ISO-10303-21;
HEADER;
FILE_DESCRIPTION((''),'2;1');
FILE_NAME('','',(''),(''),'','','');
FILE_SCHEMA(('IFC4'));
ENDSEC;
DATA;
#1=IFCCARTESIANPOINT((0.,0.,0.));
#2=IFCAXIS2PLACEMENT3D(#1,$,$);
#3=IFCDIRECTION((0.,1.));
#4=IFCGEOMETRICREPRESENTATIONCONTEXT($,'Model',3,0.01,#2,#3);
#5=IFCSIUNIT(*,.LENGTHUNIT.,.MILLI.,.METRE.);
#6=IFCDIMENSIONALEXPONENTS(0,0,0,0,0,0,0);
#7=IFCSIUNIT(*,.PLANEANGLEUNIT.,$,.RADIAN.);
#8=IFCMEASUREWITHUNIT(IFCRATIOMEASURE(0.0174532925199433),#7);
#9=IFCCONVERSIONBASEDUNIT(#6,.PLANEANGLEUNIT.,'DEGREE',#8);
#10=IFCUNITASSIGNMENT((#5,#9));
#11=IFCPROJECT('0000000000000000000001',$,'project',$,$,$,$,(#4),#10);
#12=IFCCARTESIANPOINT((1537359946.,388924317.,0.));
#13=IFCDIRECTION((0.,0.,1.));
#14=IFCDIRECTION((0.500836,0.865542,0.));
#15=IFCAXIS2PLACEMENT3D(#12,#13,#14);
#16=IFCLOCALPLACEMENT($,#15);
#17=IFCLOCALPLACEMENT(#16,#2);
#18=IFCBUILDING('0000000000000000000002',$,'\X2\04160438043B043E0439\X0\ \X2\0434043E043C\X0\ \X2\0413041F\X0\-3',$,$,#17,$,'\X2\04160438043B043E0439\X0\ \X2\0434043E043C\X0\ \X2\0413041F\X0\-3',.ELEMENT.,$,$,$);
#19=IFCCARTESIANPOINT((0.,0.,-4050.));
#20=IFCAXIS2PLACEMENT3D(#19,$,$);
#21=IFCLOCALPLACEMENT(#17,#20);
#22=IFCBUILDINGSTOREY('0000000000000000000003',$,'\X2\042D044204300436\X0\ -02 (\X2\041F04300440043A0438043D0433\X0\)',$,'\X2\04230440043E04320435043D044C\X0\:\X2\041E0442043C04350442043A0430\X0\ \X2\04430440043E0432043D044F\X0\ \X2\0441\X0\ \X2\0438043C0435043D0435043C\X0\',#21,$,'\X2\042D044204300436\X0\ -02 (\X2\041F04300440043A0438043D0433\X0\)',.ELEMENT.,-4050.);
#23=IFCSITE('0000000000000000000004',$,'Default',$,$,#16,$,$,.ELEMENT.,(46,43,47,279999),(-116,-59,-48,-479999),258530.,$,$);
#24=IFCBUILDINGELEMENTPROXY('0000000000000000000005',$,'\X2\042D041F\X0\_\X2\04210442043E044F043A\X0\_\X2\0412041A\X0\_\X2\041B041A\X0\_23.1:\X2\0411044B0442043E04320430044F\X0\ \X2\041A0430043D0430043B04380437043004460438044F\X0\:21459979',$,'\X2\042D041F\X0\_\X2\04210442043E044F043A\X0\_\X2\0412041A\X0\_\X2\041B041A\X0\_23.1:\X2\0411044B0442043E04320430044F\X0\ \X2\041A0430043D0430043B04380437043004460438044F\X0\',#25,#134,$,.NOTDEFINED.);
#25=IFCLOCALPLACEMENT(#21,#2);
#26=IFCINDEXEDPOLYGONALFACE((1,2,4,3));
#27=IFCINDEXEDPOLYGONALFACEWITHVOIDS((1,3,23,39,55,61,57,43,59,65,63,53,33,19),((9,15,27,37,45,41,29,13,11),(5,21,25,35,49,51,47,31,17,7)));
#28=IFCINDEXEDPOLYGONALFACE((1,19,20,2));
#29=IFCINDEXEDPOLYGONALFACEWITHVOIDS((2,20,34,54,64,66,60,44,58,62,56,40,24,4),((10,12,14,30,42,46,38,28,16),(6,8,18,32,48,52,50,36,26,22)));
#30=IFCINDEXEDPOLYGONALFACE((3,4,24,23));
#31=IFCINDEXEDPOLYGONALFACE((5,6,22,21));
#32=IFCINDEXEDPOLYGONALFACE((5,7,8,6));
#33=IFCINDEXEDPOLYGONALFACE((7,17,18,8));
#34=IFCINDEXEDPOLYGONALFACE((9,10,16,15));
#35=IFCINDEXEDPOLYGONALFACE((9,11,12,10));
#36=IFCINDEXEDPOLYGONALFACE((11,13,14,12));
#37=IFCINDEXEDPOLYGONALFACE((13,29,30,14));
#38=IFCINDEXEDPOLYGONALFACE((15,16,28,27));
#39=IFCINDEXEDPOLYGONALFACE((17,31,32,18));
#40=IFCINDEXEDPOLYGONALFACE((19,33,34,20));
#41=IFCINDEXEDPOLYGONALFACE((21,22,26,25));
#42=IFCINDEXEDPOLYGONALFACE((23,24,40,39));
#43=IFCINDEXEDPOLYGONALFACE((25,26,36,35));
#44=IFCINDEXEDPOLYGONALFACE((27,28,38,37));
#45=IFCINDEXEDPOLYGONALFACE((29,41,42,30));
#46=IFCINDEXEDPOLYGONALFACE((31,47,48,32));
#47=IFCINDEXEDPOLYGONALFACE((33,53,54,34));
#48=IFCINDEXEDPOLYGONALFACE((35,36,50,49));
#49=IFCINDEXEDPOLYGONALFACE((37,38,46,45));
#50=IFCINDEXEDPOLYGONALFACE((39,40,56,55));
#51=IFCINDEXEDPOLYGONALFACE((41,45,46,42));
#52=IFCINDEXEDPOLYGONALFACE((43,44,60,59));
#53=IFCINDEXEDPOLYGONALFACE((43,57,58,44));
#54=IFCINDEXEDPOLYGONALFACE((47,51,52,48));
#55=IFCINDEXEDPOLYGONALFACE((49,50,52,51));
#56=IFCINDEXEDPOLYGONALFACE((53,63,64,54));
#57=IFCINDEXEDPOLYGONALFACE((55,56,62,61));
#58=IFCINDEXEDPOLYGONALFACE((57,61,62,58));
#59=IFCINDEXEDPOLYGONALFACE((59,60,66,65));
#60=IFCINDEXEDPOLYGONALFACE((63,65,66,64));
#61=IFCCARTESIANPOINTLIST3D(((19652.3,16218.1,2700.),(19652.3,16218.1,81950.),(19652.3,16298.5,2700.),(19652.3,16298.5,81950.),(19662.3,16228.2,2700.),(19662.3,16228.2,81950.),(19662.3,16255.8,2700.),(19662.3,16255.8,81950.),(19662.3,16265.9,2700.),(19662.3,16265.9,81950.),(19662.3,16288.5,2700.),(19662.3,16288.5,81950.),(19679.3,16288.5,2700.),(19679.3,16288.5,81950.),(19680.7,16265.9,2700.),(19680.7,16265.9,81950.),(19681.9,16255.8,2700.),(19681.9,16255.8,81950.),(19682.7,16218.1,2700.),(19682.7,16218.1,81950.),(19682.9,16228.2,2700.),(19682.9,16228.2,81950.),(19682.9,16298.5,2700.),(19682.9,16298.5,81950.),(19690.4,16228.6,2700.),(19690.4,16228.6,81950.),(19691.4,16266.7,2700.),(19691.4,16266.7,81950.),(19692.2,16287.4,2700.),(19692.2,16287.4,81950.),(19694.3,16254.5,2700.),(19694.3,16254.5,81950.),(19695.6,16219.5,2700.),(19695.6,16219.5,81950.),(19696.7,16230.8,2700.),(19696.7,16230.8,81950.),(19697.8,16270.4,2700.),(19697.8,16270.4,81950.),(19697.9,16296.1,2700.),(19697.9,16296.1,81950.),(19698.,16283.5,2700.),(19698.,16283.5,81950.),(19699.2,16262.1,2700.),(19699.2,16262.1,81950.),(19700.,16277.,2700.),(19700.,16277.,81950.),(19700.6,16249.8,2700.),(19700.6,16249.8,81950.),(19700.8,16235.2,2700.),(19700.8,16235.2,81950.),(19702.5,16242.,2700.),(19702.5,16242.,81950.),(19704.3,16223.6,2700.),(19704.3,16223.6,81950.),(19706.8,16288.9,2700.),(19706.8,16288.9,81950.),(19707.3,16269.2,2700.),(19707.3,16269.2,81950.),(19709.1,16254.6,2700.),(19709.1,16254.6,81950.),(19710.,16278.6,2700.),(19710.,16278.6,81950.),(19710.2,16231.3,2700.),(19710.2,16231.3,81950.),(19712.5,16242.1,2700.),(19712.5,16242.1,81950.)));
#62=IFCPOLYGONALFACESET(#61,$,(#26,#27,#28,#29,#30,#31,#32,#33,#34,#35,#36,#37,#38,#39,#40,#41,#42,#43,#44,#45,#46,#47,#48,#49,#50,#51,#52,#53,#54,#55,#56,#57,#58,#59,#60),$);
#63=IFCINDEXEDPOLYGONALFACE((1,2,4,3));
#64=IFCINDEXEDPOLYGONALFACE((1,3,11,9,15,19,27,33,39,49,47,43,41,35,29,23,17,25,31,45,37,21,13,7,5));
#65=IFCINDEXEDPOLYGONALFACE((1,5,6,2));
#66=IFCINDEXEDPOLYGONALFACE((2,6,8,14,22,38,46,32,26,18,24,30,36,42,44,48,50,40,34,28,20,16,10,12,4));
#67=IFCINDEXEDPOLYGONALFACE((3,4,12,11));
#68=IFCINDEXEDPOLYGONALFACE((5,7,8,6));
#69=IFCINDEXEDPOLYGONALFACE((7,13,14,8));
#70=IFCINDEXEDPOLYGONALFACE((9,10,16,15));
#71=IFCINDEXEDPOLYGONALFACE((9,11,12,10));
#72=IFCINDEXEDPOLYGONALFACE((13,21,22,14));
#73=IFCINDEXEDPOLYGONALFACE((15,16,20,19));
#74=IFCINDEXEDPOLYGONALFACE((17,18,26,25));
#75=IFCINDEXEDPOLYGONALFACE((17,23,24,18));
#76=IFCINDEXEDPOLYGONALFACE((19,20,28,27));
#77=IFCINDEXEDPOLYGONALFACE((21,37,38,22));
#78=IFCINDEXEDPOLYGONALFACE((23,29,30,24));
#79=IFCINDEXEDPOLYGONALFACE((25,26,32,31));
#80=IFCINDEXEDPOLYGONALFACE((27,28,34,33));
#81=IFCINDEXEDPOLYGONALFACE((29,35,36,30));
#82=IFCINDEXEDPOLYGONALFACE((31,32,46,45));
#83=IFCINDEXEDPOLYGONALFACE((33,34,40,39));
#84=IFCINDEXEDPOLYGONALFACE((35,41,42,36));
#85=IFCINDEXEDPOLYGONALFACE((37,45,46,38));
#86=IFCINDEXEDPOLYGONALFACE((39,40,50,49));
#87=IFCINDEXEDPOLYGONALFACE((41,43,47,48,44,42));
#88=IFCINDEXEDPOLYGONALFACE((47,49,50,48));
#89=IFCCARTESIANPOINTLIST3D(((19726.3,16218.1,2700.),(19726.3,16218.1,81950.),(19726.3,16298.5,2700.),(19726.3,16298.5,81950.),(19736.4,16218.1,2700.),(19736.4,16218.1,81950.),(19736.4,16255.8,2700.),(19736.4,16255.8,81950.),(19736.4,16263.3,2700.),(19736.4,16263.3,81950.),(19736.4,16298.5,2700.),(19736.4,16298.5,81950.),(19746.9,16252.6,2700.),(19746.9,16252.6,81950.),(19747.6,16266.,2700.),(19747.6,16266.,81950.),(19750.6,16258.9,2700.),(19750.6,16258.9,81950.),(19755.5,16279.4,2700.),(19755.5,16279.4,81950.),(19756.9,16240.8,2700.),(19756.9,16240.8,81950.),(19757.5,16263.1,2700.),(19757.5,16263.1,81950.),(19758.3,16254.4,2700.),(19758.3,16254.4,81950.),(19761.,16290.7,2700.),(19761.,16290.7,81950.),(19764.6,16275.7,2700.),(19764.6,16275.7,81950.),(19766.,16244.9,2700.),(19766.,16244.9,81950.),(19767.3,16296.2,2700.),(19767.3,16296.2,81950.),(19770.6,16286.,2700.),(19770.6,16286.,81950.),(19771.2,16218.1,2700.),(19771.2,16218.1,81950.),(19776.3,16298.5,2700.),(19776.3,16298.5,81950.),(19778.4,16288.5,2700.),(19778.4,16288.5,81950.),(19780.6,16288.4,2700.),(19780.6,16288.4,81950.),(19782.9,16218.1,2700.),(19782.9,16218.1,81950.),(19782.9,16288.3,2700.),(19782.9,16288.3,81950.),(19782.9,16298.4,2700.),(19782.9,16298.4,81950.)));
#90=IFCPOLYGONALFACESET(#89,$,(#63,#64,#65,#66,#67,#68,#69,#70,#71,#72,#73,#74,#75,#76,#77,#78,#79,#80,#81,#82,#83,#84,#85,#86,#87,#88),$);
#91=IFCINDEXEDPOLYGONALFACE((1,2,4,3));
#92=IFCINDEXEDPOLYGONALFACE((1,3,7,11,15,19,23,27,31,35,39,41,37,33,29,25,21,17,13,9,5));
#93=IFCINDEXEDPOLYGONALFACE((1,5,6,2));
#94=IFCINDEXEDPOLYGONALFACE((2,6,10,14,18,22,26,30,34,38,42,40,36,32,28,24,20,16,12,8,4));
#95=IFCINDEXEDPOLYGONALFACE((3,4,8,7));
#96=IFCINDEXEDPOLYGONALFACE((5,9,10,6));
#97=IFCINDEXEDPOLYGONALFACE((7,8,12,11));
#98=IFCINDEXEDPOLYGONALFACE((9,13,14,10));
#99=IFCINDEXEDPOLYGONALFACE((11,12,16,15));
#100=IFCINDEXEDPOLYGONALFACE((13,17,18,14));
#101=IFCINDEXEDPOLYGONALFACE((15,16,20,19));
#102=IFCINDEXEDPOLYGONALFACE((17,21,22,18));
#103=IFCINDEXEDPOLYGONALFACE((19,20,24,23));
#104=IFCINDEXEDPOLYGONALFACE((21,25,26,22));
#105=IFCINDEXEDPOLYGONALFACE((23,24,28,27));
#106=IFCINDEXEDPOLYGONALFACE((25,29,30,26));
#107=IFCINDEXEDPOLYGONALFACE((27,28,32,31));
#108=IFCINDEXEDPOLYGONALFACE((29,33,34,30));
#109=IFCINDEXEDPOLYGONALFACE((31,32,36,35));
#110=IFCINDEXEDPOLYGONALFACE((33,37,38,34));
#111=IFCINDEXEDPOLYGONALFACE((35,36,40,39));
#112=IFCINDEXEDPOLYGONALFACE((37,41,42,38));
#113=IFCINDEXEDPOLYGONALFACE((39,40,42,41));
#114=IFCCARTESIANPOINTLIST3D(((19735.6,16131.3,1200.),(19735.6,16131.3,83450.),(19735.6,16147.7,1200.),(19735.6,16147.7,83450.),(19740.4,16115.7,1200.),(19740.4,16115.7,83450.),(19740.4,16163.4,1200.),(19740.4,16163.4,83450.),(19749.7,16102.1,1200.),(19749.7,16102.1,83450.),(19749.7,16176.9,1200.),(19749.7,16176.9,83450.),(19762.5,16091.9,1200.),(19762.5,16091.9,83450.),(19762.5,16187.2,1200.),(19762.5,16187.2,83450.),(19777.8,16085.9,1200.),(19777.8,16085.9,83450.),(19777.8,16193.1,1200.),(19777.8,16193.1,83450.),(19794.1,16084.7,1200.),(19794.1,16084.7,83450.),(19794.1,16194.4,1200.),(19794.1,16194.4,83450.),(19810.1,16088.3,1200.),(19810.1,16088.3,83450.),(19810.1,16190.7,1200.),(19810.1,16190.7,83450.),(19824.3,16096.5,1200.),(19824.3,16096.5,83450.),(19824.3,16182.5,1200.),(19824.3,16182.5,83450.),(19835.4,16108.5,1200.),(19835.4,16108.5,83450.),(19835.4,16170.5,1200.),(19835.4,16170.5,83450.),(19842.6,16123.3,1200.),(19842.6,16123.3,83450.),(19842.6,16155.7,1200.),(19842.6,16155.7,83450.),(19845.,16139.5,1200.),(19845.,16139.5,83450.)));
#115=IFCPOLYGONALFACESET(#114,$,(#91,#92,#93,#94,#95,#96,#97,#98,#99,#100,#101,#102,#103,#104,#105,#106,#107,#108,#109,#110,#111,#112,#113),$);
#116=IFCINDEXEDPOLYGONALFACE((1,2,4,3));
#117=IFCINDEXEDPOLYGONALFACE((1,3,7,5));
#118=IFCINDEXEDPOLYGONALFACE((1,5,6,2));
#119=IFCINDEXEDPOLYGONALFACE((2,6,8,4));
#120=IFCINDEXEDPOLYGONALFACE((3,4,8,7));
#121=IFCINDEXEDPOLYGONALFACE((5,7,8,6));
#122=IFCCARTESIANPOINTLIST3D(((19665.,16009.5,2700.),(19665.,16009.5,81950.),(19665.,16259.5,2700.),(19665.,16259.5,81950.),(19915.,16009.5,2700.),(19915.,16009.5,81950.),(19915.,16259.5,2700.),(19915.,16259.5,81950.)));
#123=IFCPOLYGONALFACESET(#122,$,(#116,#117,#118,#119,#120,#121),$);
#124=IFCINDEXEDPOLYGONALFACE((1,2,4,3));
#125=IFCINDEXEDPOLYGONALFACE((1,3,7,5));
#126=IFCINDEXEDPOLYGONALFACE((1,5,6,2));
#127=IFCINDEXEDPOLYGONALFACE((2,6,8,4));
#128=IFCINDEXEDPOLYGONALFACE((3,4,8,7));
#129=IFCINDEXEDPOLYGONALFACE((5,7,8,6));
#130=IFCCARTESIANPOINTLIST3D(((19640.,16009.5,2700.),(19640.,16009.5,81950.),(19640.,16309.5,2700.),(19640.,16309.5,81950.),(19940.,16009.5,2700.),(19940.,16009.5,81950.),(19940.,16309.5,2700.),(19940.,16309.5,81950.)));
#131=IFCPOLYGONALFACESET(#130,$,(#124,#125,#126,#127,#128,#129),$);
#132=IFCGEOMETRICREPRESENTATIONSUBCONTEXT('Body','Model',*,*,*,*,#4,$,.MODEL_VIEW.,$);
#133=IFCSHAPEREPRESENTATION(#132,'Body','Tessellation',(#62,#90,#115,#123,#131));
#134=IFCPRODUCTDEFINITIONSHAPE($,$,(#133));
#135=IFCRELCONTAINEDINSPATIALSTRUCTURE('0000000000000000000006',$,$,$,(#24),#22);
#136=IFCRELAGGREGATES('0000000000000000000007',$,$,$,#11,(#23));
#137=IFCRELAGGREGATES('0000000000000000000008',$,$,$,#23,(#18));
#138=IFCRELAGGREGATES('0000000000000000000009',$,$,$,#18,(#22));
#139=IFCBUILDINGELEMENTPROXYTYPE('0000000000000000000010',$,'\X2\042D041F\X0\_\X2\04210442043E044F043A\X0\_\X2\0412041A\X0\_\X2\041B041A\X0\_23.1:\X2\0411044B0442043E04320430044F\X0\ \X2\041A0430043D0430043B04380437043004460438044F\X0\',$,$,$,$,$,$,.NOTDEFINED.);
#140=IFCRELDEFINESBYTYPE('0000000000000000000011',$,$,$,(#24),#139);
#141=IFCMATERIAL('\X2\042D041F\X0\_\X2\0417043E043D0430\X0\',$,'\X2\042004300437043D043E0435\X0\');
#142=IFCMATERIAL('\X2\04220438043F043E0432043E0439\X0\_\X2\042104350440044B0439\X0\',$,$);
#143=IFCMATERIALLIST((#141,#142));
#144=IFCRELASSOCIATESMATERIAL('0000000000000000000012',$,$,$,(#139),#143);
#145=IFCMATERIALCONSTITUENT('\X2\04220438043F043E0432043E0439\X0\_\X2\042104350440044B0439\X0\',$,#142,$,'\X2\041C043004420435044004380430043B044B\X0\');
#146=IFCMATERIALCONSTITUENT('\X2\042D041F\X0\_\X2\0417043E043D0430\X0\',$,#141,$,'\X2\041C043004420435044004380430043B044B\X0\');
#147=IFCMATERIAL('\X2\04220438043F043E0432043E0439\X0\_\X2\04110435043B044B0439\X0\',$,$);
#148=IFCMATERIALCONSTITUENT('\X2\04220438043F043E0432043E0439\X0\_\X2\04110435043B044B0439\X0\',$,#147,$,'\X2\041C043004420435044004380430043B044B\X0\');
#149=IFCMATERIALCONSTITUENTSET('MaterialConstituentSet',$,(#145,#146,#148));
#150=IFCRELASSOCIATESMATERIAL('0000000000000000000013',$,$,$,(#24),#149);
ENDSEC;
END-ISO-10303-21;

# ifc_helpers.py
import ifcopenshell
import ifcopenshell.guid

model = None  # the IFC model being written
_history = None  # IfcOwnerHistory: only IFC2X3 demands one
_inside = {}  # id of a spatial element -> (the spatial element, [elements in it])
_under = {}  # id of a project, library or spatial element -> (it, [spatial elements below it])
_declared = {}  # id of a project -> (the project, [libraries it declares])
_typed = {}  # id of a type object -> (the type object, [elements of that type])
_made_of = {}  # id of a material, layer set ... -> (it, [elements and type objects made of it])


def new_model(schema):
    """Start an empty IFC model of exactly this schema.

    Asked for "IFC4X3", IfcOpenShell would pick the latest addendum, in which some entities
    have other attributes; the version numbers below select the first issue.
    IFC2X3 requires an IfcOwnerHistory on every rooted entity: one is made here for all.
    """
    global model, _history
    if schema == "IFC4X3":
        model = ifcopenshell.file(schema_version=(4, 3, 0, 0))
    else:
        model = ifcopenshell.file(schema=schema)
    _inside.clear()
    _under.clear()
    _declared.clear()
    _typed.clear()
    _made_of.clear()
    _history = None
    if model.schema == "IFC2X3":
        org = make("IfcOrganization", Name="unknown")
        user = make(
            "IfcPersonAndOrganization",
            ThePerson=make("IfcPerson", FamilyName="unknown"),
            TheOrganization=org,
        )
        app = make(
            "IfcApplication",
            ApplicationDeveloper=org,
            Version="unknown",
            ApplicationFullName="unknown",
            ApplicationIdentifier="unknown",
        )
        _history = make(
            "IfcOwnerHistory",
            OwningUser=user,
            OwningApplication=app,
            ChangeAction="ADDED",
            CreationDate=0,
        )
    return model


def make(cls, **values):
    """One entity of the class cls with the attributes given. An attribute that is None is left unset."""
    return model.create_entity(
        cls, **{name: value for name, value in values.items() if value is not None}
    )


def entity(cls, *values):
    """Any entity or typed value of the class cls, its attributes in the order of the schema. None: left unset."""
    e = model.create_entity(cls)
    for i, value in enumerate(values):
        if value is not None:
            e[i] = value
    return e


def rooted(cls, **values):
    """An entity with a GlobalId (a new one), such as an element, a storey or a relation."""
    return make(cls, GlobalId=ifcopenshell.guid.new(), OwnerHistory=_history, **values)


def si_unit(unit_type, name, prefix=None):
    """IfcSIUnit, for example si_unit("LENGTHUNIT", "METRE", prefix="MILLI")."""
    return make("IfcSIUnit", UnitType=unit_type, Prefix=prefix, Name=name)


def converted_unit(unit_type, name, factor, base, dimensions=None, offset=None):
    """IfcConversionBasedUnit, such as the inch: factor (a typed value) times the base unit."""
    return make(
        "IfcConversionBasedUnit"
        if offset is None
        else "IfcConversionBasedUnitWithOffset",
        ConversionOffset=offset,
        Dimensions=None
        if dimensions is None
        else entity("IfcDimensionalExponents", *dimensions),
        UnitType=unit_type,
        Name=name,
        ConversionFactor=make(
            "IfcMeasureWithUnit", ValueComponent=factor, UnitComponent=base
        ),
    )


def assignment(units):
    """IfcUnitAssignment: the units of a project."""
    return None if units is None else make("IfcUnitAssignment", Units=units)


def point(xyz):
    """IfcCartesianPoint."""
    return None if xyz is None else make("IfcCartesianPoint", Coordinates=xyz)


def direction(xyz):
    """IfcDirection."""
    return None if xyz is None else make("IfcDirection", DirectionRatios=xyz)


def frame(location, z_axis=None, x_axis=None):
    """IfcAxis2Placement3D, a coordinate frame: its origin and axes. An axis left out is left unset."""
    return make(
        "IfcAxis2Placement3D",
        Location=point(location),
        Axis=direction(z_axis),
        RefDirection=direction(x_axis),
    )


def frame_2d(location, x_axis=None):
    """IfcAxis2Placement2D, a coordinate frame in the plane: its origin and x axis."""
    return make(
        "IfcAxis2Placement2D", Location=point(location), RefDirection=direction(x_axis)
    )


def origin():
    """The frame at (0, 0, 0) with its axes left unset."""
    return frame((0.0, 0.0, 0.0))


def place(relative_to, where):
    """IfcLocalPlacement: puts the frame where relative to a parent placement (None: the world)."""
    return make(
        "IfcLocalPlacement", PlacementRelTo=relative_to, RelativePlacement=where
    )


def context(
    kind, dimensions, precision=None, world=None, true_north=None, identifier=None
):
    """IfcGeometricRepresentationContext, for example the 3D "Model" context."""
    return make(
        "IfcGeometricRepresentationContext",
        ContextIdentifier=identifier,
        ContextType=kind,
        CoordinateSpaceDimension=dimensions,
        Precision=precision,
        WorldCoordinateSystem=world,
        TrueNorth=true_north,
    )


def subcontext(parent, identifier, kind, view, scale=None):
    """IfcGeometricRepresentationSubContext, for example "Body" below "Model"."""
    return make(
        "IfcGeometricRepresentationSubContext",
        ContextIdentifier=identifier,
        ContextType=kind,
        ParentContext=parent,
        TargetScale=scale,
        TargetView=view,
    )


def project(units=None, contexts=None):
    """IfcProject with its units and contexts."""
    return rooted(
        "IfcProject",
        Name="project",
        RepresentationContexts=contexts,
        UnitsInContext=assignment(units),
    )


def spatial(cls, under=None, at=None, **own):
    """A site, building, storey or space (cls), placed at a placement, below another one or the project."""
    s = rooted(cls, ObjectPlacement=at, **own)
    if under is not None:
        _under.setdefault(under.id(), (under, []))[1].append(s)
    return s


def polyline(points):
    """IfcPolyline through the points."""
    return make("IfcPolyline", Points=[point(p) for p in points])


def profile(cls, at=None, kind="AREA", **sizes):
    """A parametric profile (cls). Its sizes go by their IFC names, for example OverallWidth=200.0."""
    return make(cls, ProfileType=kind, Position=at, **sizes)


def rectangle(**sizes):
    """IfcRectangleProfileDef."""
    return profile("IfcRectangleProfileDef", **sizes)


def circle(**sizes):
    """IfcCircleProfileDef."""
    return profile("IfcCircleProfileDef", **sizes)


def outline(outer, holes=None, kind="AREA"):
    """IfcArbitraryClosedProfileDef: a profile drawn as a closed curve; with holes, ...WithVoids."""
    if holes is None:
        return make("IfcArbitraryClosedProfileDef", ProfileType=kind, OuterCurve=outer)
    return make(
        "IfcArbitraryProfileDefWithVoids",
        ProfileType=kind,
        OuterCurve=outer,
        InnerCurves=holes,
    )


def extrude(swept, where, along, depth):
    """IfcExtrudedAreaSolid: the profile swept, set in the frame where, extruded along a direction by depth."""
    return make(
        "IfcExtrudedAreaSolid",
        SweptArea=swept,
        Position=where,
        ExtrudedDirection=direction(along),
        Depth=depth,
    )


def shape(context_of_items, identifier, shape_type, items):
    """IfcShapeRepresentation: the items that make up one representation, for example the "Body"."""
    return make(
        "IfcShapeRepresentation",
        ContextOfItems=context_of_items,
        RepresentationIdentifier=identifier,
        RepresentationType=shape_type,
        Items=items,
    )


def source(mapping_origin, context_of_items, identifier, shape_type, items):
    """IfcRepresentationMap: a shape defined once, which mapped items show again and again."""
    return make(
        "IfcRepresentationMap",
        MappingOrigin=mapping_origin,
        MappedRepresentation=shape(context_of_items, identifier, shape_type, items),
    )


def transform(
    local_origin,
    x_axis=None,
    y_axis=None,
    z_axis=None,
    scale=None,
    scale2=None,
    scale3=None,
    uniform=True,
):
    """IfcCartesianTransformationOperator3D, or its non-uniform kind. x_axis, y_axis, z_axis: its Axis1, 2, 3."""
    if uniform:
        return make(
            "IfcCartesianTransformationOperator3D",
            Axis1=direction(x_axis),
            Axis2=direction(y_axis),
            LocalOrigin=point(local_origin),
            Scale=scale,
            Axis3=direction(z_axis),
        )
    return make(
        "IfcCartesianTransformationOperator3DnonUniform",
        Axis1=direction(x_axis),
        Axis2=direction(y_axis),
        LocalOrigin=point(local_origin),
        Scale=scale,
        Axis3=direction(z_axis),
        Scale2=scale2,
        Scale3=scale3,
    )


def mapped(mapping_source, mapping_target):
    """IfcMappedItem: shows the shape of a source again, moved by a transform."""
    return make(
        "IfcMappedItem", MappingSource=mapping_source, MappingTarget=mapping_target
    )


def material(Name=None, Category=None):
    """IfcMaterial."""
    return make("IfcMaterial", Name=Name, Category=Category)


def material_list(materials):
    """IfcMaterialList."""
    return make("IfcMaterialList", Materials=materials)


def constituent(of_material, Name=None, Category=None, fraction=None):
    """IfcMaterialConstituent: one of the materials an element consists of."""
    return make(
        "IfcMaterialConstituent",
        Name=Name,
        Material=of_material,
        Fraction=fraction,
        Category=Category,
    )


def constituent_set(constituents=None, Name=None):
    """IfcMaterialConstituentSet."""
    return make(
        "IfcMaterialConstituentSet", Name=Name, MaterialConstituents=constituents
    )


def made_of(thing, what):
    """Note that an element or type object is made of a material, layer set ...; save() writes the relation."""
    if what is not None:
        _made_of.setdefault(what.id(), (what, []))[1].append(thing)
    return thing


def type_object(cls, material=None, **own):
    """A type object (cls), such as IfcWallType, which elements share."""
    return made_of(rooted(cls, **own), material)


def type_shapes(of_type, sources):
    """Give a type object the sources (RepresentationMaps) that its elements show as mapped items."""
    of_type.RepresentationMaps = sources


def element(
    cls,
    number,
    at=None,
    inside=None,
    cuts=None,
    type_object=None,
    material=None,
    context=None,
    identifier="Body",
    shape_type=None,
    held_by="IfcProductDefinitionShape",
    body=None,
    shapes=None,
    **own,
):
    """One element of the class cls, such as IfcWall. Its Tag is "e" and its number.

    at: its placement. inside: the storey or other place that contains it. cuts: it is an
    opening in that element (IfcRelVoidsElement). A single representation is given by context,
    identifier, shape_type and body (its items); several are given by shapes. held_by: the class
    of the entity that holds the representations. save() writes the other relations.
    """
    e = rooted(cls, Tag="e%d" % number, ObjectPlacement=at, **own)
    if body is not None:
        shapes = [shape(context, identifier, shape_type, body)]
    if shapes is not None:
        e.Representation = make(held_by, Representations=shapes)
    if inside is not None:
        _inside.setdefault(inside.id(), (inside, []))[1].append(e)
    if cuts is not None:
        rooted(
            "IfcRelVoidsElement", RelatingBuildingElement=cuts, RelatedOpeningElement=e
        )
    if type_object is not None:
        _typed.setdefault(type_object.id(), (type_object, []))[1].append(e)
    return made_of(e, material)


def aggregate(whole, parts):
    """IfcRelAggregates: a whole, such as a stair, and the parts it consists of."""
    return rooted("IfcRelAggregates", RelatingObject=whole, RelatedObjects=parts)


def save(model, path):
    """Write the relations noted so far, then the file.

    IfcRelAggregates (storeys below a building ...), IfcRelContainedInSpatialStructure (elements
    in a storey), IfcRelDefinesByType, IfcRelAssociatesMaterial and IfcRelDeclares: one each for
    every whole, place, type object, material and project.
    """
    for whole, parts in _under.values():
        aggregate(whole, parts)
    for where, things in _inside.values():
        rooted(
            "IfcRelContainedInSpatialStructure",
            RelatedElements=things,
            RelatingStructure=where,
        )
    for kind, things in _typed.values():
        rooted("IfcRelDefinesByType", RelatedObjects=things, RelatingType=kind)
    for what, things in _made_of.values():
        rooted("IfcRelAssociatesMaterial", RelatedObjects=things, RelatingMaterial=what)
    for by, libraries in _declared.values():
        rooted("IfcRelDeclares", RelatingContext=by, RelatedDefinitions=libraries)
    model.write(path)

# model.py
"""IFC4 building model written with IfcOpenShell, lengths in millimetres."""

from ifc_helpers import new_model, entity, si_unit, converted_unit, direction, frame, frame_2d, origin, place, context, subcontext, project, spatial, polyline, rectangle, circle, outline, extrude, source, transform, mapped, material, material_list, constituent, constituent_set, type_object, type_shapes, element, save


model = new_model("IFC4")

# Units and contexts
model_context = context("Model", 3, precision=0.01, world=origin(), true_north=direction((0.0, 1.0)))
body_context = subcontext(model_context, "Body", "Model", "MODEL_VIEW")
ifc_project = project(units=[si_unit("LENGTHUNIT", "METRE", prefix="MILLI"), converted_unit("PLANEANGLEUNIT", "DEGREE", entity("IfcRatioMeasure", 0.0174532925199433), si_unit("PLANEANGLEUNIT", "RADIAN"), dimensions=[0, 0, 0, 0, 0, 0, 0])], contexts=[model_context])

# Site, building, storey
site_placement = place(None, frame((1537359946.0, 388924317.0, 0.0), z_axis=(0.0, 0.0, 1.0), x_axis=(0.500836, 0.865542, 0.0)))
site = spatial("IfcSite", under=ifc_project, at=site_placement, Name="Default", CompositionType="ELEMENT", RefLatitude=(46, 43, 47, 279999), RefLongitude=(-116, -59, -48, -479999), RefElevation=258530.0)
building_placement = place(site_placement, origin())
building = spatial("IfcBuilding", under=site, at=building_placement, Name="Жилой дом ГП-3", LongName="Жилой дом ГП-3", CompositionType="ELEMENT")
storey_placement = place(building_placement, frame((0.0, 0.0, -4050.0)))
storey = spatial("IfcBuildingStorey", under=building, at=storey_placement, Name="Этаж -02 (Паркинг)", ObjectType="Уровень:Отметка уровня с именем", LongName="Этаж -02 (Паркинг)", CompositionType="ELEMENT", Elevation=-4050.0)

# Building element proxy
ifc_material_1 = material(Name="ЭП_Зона", Category="Разное")
ifc_material_2 = material(Name="Типовой_Белый")
ifc_material_3 = material(Name="Типовой_Серый")
ifc_material_list_1 = material_list([ifc_material_1, ifc_material_3])
building_element_proxy_type_1 = type_object("IfcBuildingElementProxyType", Name="ЭП_Стояк_ВК_ЛК_23.1:Бытовая Канализация", PredefinedType="NOTDEFINED", material=ifc_material_list_1)
shared_shape_1 = source(origin(), body_context, "Body", "SweptSolid", [
    extrude(outline(polyline([(-42.2, -39.0), (-11.8, -39.0), (1.1, -37.6), (9.8, -33.5), (15.7, -25.8), (18.0, -15.0), (14.6, -2.5), (4.7, 5.0), (12.8, 12.1), (15.5, 21.5), (12.3, 31.8), (3.4, 39.0), (-11.6, 41.4), (-42.2, 41.4), (-42.2, -39.0)]), holes=[polyline([(-32.2, 8.8), (-32.2, 31.4), (-15.2, 31.4), (-2.3, 30.3), (3.5, 26.4), (5.5, 19.9), (3.3, 13.3), (-3.1, 9.6), (-13.9, 8.8), (-32.2, 8.8)]), polyline([(-32.2, -28.9), (-32.2, -1.3), (-12.6, -1.3), (-0.2, -2.6), (6.1, -7.3), (8.0, -15.1), (6.3, -21.9), (2.2, -26.3), (-4.1, -28.5), (-11.6, -28.9), (-32.2, -28.9)])]), frame((54.5, -52.4, -1350.0)), (0.0, 0.0, 1.0), 79250.0),
    extrude(outline(polyline([(-32.1, -31.9), (48.3, -31.9), (48.3, -21.8), (10.6, -21.8), (13.8, -11.4), (25.6, -1.3), (48.3, 13.0), (48.3, 24.6), (21.4, 7.7), (12.0, 0.1), (7.4, -7.7), (3.3, -0.7), (-9.3, 6.4), (-19.7, 12.3), (-22.1, 20.2), (-22.0, 22.4), (-22.0, 24.6), (-32.0, 24.6), (-32.1, 18.0), (-29.9, 9.0), (-24.3, 2.8), (-13.1, -2.8), (0.4, -10.6), (3.0, -21.8), (-32.1, -21.8), (-32.1, -31.9)])), frame((118.2, -43.1, -1350.0), z_axis=(0.0, 0.0, 1.0), x_axis=(0.0, -1.0, 0.0)), (0.0, 0.0, 1.0), 79250.0),
    extrude(circle(Radius=55.0, at=frame_2d((0.0, 0.0), x_axis=(1.0, 0.0))), frame((150.0, -170.0, -2850.0)), (0.0, 0.0, 1.0), 82250.0),
    extrude(rectangle(XDim=250.0, YDim=250.0, at=frame_2d((0.0, 0.0), x_axis=(1.0, 0.0))), frame((150.0, -175.0, -1350.0)), (0.0, 0.0, 1.0), 79250.0),
    extrude(rectangle(XDim=300.0, YDim=300.0, at=frame_2d((0.0, 0.0), x_axis=(1.0, 0.0))), frame((150.0, -150.0, -1350.0)), (0.0, 0.0, 1.0), 79250.0),
])
type_shapes(building_element_proxy_type_1, [shared_shape_1])
ifc_constituent_1 = constituent(ifc_material_3, Name="Типовой_Серый", Category="Материалы")
ifc_constituent_2 = constituent(ifc_material_1, Name="ЭП_Зона", Category="Материалы")
ifc_constituent_3 = constituent(ifc_material_2, Name="Типовой_Белый", Category="Материалы")
ifc_constituent_set_1 = constituent_set(constituents=[ifc_constituent_1, ifc_constituent_2, ifc_constituent_3], Name="MaterialConstituentSet")
proxy_1_placement = place(storey_placement, frame((19640.0, 16309.5, 4050.0)))
element("IfcBuildingElementProxy", 1, at=proxy_1_placement, inside=storey, type_object=building_element_proxy_type_1, material=ifc_constituent_set_1, Name="ЭП_Стояк_ВК_ЛК_23.1:Бытовая Канализация:21459979", ObjectType="ЭП_Стояк_ВК_ЛК_23.1:Бытовая Канализация", PredefinedType="NOTDEFINED", context=body_context, shape_type="MappedRepresentation", body=[
    mapped(shared_shape_1, transform((0.0, 0.0, 0.0), scale=1.0)),
])

save(model, "model.ifc")
